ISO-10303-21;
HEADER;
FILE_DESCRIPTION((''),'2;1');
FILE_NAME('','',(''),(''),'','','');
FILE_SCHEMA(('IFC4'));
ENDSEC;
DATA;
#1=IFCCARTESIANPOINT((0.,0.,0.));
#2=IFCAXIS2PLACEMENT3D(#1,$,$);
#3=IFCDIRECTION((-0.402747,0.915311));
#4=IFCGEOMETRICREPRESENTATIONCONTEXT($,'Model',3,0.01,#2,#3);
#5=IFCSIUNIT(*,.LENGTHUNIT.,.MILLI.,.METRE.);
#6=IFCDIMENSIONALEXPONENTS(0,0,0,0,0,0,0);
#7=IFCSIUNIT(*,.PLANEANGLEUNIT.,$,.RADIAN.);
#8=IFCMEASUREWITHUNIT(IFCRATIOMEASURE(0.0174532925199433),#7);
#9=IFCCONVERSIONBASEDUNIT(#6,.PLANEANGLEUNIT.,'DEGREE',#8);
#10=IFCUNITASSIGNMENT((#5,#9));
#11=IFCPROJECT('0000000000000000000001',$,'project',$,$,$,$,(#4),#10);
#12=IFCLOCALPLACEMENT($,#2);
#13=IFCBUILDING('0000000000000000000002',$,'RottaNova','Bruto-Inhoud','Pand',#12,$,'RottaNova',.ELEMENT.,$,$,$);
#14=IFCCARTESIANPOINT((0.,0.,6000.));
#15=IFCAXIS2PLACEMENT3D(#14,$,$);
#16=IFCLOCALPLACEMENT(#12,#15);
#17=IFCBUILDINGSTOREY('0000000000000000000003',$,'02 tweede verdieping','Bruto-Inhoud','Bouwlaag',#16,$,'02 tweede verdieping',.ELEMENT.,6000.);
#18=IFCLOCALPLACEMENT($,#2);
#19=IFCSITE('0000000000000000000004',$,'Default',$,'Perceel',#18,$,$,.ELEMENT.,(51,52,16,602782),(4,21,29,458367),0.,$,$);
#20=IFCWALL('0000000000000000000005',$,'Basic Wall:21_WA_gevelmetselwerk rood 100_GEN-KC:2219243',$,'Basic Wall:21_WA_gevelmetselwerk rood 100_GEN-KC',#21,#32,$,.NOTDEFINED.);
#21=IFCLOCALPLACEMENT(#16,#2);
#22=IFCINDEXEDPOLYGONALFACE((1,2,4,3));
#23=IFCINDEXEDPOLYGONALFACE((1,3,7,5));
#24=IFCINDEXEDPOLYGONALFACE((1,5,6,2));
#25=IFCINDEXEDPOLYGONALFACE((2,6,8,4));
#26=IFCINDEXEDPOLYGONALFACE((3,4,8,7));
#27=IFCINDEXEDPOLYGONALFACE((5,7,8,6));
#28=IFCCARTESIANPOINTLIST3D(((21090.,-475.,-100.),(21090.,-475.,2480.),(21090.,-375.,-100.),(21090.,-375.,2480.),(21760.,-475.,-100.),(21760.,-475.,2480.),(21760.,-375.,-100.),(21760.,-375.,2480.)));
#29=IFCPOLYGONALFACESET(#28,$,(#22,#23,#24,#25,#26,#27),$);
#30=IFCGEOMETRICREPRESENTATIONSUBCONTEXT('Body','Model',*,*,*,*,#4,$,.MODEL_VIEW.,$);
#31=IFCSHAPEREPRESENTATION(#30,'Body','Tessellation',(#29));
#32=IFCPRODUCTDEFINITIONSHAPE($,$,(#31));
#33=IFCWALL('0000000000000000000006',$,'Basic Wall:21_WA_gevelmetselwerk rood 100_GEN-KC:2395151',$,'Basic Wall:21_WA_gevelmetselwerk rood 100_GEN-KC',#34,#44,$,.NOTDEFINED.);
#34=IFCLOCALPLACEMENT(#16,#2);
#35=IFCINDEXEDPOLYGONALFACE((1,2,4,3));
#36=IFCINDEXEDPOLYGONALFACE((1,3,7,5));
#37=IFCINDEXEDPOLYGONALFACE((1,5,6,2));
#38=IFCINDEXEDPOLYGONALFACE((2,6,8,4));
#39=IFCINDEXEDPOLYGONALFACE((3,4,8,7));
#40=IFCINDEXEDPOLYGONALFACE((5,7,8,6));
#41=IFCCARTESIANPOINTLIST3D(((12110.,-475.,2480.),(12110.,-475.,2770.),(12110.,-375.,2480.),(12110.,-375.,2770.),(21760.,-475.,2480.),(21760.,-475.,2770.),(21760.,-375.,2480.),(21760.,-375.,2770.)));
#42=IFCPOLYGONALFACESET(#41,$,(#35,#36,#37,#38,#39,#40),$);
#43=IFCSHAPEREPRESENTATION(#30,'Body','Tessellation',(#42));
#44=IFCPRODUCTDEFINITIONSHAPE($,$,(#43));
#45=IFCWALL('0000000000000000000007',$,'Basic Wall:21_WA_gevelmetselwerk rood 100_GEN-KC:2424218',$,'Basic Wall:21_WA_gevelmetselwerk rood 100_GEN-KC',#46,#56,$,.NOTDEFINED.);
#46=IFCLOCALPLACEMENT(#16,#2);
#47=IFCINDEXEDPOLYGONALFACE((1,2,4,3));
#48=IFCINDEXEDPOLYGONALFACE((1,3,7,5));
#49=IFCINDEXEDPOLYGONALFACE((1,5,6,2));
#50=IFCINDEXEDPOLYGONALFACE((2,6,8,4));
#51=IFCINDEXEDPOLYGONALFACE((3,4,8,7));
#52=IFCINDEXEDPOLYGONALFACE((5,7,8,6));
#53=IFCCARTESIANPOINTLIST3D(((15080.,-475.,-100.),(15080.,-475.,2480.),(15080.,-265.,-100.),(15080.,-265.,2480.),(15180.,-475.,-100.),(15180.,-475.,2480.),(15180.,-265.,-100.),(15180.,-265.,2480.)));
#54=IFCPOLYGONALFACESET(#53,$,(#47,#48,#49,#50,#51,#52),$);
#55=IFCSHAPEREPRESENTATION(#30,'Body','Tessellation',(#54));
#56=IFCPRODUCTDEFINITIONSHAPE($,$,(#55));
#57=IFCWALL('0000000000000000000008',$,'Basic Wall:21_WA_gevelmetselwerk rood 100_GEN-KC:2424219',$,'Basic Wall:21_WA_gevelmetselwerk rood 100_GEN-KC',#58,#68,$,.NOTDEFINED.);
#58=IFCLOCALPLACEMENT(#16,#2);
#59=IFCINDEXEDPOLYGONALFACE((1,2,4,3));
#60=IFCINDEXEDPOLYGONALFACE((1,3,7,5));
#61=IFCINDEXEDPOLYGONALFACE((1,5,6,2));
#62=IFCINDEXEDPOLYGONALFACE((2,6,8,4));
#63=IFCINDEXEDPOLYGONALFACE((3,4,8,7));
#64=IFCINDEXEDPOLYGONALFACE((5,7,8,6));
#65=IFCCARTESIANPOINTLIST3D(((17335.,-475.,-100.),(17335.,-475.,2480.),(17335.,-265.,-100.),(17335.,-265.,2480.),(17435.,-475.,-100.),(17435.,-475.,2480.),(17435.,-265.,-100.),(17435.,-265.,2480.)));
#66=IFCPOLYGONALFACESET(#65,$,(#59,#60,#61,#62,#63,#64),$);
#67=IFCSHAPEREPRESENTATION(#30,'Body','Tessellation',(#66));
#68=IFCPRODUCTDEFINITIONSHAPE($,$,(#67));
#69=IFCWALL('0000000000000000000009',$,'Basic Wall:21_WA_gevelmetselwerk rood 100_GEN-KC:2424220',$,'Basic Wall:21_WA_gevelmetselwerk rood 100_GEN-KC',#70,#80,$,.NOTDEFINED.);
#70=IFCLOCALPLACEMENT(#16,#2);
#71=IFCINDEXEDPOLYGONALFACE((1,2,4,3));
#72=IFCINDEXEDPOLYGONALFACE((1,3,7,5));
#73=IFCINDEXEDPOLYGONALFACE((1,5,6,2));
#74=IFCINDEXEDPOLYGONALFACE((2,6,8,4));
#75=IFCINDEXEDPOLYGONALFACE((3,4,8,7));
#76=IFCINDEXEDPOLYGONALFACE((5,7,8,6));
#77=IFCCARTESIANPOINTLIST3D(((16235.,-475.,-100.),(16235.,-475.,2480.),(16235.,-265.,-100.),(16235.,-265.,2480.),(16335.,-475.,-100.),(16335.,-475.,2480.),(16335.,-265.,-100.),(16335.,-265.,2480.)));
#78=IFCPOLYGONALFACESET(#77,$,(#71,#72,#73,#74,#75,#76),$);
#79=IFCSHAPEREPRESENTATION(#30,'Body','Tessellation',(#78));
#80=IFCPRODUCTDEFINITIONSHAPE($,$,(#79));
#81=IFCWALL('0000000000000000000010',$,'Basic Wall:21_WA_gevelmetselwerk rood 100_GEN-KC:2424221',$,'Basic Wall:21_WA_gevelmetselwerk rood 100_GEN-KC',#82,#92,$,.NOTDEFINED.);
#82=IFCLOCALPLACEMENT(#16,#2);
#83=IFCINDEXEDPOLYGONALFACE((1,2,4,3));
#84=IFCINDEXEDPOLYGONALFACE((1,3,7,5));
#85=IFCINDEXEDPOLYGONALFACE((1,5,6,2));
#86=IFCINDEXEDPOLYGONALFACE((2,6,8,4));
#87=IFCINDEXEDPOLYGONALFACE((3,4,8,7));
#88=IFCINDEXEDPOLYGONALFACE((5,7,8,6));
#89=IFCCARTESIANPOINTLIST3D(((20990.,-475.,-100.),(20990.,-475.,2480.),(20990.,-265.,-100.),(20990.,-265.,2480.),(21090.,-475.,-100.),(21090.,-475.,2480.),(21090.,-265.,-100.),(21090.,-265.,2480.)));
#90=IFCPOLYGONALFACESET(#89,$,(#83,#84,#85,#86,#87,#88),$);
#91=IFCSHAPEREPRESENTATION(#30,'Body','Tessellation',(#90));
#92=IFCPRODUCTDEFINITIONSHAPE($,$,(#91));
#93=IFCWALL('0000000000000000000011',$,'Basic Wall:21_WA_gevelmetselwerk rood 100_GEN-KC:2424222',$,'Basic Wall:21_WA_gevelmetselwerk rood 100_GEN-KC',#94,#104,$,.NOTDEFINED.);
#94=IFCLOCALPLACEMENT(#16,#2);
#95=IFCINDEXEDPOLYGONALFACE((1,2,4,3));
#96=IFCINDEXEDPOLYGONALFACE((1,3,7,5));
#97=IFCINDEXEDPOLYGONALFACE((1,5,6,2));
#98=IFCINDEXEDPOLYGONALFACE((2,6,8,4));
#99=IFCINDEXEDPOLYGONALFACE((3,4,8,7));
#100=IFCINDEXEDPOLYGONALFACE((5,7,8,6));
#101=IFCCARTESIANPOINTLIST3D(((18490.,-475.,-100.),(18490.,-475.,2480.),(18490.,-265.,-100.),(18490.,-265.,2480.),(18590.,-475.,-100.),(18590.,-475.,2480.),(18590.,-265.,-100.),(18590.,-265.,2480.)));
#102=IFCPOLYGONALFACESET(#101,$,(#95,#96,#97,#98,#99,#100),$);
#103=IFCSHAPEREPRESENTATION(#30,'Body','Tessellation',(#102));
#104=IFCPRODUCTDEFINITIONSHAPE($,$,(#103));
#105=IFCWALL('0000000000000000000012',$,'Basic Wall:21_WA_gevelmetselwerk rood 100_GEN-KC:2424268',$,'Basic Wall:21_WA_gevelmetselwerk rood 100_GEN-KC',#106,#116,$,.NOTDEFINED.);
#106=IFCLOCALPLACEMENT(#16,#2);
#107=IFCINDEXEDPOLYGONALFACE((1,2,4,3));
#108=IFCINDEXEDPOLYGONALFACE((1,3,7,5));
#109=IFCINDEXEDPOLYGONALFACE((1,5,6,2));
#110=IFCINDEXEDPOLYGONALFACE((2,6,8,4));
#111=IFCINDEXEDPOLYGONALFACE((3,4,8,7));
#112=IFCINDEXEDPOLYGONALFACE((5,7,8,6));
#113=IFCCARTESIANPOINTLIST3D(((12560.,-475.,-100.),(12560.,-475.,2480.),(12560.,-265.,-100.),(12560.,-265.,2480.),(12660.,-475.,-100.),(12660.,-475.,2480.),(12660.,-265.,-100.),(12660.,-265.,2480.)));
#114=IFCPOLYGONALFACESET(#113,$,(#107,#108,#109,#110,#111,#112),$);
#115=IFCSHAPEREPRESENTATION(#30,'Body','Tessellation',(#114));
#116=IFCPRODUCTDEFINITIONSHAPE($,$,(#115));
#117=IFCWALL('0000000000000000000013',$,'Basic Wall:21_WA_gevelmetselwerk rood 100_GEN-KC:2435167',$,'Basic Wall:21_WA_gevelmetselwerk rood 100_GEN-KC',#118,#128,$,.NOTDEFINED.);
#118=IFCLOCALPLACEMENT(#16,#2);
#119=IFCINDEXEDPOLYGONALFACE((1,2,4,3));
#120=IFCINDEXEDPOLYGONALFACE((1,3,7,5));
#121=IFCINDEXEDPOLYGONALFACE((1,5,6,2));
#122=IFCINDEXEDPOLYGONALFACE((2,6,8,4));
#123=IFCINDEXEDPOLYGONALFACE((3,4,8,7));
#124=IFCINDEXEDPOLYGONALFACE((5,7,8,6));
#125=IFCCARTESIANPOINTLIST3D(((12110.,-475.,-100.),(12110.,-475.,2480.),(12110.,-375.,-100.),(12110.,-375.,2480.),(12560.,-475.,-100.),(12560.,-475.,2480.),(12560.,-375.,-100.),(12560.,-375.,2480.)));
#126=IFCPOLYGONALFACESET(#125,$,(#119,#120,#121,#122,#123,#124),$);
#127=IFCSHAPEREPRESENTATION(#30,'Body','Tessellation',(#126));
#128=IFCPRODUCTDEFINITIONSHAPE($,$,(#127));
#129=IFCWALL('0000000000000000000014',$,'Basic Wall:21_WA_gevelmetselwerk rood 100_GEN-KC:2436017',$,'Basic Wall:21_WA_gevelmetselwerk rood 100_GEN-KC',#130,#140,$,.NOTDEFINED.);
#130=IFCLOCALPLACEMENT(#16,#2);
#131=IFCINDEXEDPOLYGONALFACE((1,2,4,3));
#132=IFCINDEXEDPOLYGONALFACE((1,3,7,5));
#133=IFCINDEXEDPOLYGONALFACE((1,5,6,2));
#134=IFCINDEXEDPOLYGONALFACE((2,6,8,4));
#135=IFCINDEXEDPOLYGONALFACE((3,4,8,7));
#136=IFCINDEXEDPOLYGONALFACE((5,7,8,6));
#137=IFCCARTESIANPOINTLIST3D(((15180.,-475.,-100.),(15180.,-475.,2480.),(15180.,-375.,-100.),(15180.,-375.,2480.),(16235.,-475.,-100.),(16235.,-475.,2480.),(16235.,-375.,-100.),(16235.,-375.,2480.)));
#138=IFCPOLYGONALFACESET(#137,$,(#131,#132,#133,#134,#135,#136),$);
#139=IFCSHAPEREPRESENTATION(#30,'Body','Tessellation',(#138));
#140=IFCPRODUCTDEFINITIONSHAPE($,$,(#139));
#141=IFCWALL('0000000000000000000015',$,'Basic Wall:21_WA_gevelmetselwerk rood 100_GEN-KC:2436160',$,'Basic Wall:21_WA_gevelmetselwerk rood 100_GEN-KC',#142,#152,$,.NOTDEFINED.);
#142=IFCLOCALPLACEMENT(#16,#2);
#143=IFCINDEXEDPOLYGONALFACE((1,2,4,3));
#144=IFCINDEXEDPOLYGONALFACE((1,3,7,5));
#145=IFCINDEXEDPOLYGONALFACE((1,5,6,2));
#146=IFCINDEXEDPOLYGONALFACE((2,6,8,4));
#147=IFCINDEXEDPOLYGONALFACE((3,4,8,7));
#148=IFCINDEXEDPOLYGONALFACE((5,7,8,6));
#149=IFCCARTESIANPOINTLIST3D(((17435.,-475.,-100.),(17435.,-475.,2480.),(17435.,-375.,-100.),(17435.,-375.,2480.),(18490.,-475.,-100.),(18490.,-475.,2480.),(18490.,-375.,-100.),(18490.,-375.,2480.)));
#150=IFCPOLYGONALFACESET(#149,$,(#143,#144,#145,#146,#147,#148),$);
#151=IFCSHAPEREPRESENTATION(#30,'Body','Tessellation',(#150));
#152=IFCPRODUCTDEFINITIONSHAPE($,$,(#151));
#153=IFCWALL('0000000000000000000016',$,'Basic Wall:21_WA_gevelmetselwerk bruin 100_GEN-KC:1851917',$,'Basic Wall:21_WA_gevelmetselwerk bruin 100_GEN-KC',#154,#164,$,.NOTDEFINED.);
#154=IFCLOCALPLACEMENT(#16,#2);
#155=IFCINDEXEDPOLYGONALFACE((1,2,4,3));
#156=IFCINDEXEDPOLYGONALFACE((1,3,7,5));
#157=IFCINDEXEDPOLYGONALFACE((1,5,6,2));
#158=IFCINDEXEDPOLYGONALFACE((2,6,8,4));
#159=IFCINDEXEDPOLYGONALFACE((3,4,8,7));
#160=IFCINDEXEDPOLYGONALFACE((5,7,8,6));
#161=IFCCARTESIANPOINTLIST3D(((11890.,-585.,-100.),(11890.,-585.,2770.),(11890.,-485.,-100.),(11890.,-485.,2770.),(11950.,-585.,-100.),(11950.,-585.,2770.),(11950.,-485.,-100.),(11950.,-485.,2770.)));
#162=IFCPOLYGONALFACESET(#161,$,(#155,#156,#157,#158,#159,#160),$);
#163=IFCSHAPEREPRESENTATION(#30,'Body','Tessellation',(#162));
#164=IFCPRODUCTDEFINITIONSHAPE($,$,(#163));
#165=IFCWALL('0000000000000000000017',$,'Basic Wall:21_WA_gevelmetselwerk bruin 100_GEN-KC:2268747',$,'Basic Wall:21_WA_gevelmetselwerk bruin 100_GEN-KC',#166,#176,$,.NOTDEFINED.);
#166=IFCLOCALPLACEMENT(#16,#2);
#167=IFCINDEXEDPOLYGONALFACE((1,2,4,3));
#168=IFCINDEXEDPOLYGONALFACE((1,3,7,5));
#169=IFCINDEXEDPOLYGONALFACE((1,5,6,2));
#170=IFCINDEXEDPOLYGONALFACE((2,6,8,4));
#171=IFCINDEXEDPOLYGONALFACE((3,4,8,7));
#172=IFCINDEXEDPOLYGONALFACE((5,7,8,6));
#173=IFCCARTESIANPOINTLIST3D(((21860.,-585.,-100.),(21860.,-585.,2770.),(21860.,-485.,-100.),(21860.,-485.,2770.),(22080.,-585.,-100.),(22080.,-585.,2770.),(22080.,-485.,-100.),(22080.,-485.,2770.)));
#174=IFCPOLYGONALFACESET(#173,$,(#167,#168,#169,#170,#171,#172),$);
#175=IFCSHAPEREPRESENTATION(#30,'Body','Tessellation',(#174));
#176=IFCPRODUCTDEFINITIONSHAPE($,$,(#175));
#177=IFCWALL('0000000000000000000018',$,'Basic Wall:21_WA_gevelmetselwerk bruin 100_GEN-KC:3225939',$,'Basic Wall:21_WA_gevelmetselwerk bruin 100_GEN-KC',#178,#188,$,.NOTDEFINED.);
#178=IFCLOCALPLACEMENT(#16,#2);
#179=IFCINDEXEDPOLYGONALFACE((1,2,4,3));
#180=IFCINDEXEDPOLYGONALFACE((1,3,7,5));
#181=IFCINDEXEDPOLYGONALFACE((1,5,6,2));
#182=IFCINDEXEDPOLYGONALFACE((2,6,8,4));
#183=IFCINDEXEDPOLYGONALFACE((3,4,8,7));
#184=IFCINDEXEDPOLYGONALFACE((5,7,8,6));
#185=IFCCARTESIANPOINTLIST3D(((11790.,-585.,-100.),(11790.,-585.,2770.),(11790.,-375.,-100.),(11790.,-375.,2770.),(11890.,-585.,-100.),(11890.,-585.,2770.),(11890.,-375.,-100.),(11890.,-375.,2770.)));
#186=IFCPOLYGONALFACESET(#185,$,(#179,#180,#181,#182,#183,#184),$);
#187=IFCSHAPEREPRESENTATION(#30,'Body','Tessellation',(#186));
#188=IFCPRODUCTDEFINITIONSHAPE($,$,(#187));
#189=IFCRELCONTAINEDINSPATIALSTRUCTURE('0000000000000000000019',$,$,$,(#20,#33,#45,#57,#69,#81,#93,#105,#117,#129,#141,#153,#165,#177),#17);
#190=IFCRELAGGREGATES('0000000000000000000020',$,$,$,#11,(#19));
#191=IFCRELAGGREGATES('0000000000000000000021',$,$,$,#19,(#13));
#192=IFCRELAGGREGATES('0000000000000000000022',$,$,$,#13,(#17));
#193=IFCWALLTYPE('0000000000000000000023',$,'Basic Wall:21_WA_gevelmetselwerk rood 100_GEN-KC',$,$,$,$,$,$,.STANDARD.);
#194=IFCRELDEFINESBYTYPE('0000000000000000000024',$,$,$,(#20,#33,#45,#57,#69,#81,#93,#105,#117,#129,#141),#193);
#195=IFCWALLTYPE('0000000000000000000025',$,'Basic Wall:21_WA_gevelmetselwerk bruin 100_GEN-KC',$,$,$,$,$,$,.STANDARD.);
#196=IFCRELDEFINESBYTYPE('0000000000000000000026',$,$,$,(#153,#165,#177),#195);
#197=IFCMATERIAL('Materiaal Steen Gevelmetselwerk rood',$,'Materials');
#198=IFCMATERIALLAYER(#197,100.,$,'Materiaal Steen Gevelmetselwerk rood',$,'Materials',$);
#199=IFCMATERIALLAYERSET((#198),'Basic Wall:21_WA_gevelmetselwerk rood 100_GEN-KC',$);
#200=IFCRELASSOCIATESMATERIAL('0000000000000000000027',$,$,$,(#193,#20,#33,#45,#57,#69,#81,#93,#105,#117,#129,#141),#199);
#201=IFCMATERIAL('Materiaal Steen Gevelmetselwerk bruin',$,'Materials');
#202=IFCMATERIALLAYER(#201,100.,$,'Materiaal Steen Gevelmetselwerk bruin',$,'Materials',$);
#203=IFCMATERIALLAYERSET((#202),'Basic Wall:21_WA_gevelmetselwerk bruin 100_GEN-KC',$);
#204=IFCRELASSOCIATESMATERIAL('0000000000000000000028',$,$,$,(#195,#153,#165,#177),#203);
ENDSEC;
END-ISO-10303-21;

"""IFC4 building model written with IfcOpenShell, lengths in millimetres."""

from ifc_helpers import new_model, entity, si_unit, converted_unit, direction, frame, frame_2d, origin, place, context, subcontext, project, spatial, rectangle, extrude, material, layer, layer_set, type_object, element, save


model = new_model("IFC4")

# Units and contexts
model_context = context("Model", 3, precision=0.01, world=origin(), true_north=direction((-0.402747, 0.915311)))
body_context = subcontext(model_context, "Body", "Model", "MODEL_VIEW")
ifc_project = project(units=[si_unit("LENGTHUNIT", "METRE", prefix="MILLI"), converted_unit("PLANEANGLEUNIT", "DEGREE", entity("IfcRatioMeasure", 0.0174532925199433), si_unit("PLANEANGLEUNIT", "RADIAN"), dimensions=[0, 0, 0, 0, 0, 0, 0])], contexts=[model_context])

# Site, building, storey
site_placement = place(None, origin())
site = spatial("IfcSite", under=ifc_project, at=site_placement, Name="Default", ObjectType="Perceel", CompositionType="ELEMENT", RefLatitude=(51, 52, 16, 602782), RefLongitude=(4, 21, 29, 458367), RefElevation=0.0)
building_placement = place(None, origin())
building = spatial("IfcBuilding", under=site, at=building_placement, Name="RottaNova", Description="Bruto-Inhoud", ObjectType="Pand", LongName="RottaNova", CompositionType="ELEMENT")
storey_placement = place(building_placement, frame((0.0, 0.0, 6000.0)))
storey = spatial("IfcBuildingStorey", under=building, at=storey_placement, Name="02 tweede verdieping", Description="Bruto-Inhoud", ObjectType="Bouwlaag", LongName="02 tweede verdieping", CompositionType="ELEMENT", Elevation=6000.0)

# Walls
ifc_material_1 = material(Name="Materiaal Steen Gevelmetselwerk rood", Category="Materials")
ifc_layer_1 = layer(ifc_material_1, 100.0, Name="Materiaal Steen Gevelmetselwerk rood", Category="Materials")
ifc_layer_set_1 = layer_set([ifc_layer_1], Name="Basic Wall:21_WA_gevelmetselwerk rood 100_GEN-KC")
wall_type_1 = type_object("IfcWallType", Name="Basic Wall:21_WA_gevelmetselwerk rood 100_GEN-KC", PredefinedType="STANDARD", material=ifc_layer_set_1)
wall_1_placement = place(storey_placement, frame((21760.0, -425.0, -100.0), z_axis=(0.0, 0.0, 1.0), x_axis=(-1.0, 0.0, 0.0)))
element("IfcWall", 1, at=wall_1_placement, inside=storey, type_object=wall_type_1, material=ifc_layer_set_1, Name="Basic Wall:21_WA_gevelmetselwerk rood 100_GEN-KC:2219243", ObjectType="Basic Wall:21_WA_gevelmetselwerk rood 100_GEN-KC", PredefinedType="NOTDEFINED", context=body_context, shape_type="SweptSolid", body=[
    extrude(rectangle(XDim=670.0, YDim=100.0, at=frame_2d((335.0, 0.0), x_axis=(-1.0, 0.0))), origin(), (0.0, 0.0, 1.0), 2580.0),
])
wall_2_placement = place(storey_placement, frame((21760.0, -425.0, 2480.0), z_axis=(0.0, 0.0, 1.0), x_axis=(-1.0, 0.0, 0.0)))
element("IfcWall", 2, at=wall_2_placement, inside=storey, type_object=wall_type_1, material=ifc_layer_set_1, Name="Basic Wall:21_WA_gevelmetselwerk rood 100_GEN-KC:2395151", ObjectType="Basic Wall:21_WA_gevelmetselwerk rood 100_GEN-KC", PredefinedType="NOTDEFINED", context=body_context, shape_type="SweptSolid", body=[
    extrude(rectangle(XDim=9650.0, YDim=100.0, at=frame_2d((4825.0, 0.0), x_axis=(-1.0, 0.0))), origin(), (0.0, 0.0, 1.0), 290.0),
])
for number, where, z_axis, x_axis, name in (
    (3, (15130.0, -265.0, -100.0), (0.0, 0.0, 1.0), (0.0, -1.0, 0.0), "Basic Wall:21_WA_gevelmetselwerk rood 100_GEN-KC:2424218"),
    (4, (17385.0, -265.0, -100.0), (0.0, 0.0, 1.0), (0.0, -1.0, 0.0), "Basic Wall:21_WA_gevelmetselwerk rood 100_GEN-KC:2424219"),
    (5, (16285.0, -265.0, -100.0), (0.0, 0.0, 1.0), (0.0, -1.0, 0.0), "Basic Wall:21_WA_gevelmetselwerk rood 100_GEN-KC:2424220"),
):
    element("IfcWall", number, at=place(storey_placement, frame(where, z_axis=z_axis, x_axis=x_axis)), inside=storey, type_object=wall_type_1, material=ifc_layer_set_1, Name=name, ObjectType="Basic Wall:21_WA_gevelmetselwerk rood 100_GEN-KC", PredefinedType="NOTDEFINED", context=body_context, shape_type="SweptSolid", body=[
        extrude(rectangle(XDim=210.0, YDim=100.0, at=frame_2d((105.0, 0.0), x_axis=(-1.0, 0.0))), origin(), (0.0, 0.0, 1.0), 2580.0),
    ])
wall_3_placement = place(storey_placement, frame((21040.0, -265.0, -100.0), z_axis=(0.0, 0.0, 1.0), x_axis=(0.0, -1.0, 0.0)))
element("IfcWall", 6, at=wall_3_placement, inside=storey, type_object=wall_type_1, material=ifc_layer_set_1, Name="Basic Wall:21_WA_gevelmetselwerk rood 100_GEN-KC:2424221", ObjectType="Basic Wall:21_WA_gevelmetselwerk rood 100_GEN-KC", PredefinedType="NOTDEFINED", context=body_context, shape_type="SweptSolid", body=[
    extrude(rectangle(XDim=210.0, YDim=100.0, at=frame_2d((105.0, 0.0), x_axis=(-1.0, 0.0))), origin(), (0.0, 0.0, 1.0), 2580.0),
])
wall_4_placement = place(storey_placement, frame((18540.0, -265.0, -100.0), z_axis=(0.0, 0.0, 1.0), x_axis=(0.0, -1.0, 0.0)))
element("IfcWall", 7, at=wall_4_placement, inside=storey, type_object=wall_type_1, material=ifc_layer_set_1, Name="Basic Wall:21_WA_gevelmetselwerk rood 100_GEN-KC:2424222", ObjectType="Basic Wall:21_WA_gevelmetselwerk rood 100_GEN-KC", PredefinedType="NOTDEFINED", context=body_context, shape_type="SweptSolid", body=[
    extrude(rectangle(XDim=210.0, YDim=100.0, at=frame_2d((105.0, 0.0), x_axis=(-1.0, 0.0))), origin(), (0.0, 0.0, 1.0), 2580.0),
])
wall_5_placement = place(storey_placement, frame((12610.0, -265.0, -100.0), z_axis=(0.0, 0.0, 1.0), x_axis=(0.0, -1.0, 0.0)))
element("IfcWall", 8, at=wall_5_placement, inside=storey, type_object=wall_type_1, material=ifc_layer_set_1, Name="Basic Wall:21_WA_gevelmetselwerk rood 100_GEN-KC:2424268", ObjectType="Basic Wall:21_WA_gevelmetselwerk rood 100_GEN-KC", PredefinedType="NOTDEFINED", context=body_context, shape_type="SweptSolid", body=[
    extrude(rectangle(XDim=210.0, YDim=100.0, at=frame_2d((105.0, 0.0), x_axis=(-1.0, 0.0))), origin(), (0.0, 0.0, 1.0), 2580.0),
])
wall_6_placement = place(storey_placement, frame((12560.0, -425.0, -100.0), z_axis=(0.0, 0.0, 1.0), x_axis=(-1.0, 0.0, 0.0)))
element("IfcWall", 9, at=wall_6_placement, inside=storey, type_object=wall_type_1, material=ifc_layer_set_1, Name="Basic Wall:21_WA_gevelmetselwerk rood 100_GEN-KC:2435167", ObjectType="Basic Wall:21_WA_gevelmetselwerk rood 100_GEN-KC", PredefinedType="NOTDEFINED", context=body_context, shape_type="SweptSolid", body=[
    extrude(rectangle(XDim=450.0, YDim=100.0, at=frame_2d((225.0, 0.0), x_axis=(-1.0, 0.0))), origin(), (0.0, 0.0, 1.0), 2580.0),
])
wall_7_placement = place(storey_placement, frame((16235.0, -425.0, -100.0), z_axis=(0.0, 0.0, 1.0), x_axis=(-1.0, 0.0, 0.0)))
element("IfcWall", 10, at=wall_7_placement, inside=storey, type_object=wall_type_1, material=ifc_layer_set_1, Name="Basic Wall:21_WA_gevelmetselwerk rood 100_GEN-KC:2436017", ObjectType="Basic Wall:21_WA_gevelmetselwerk rood 100_GEN-KC", PredefinedType="NOTDEFINED", context=body_context, shape_type="SweptSolid", body=[
    extrude(rectangle(XDim=1055.0, YDim=100.0, at=frame_2d((527.5, 0.0), x_axis=(-1.0, 0.0))), origin(), (0.0, 0.0, 1.0), 2580.0),
])
wall_8_placement = place(storey_placement, frame((18490.0, -425.0, -100.0), z_axis=(0.0, 0.0, 1.0), x_axis=(-1.0, 0.0, 0.0)))
element("IfcWall", 11, at=wall_8_placement, inside=storey, type_object=wall_type_1, material=ifc_layer_set_1, Name="Basic Wall:21_WA_gevelmetselwerk rood 100_GEN-KC:2436160", ObjectType="Basic Wall:21_WA_gevelmetselwerk rood 100_GEN-KC", PredefinedType="NOTDEFINED", context=body_context, shape_type="SweptSolid", body=[
    extrude(rectangle(XDim=1055.0, YDim=100.0, at=frame_2d((527.5, 0.0), x_axis=(-1.0, 0.0))), origin(), (0.0, 0.0, 1.0), 2580.0),
])
ifc_material_2 = material(Name="Materiaal Steen Gevelmetselwerk bruin", Category="Materials")
ifc_layer_2 = layer(ifc_material_2, 100.0, Name="Materiaal Steen Gevelmetselwerk bruin", Category="Materials")
ifc_layer_set_2 = layer_set([ifc_layer_2], Name="Basic Wall:21_WA_gevelmetselwerk bruin 100_GEN-KC")
wall_type_2 = type_object("IfcWallType", Name="Basic Wall:21_WA_gevelmetselwerk bruin 100_GEN-KC", PredefinedType="STANDARD", material=ifc_layer_set_2)
wall_9_placement = place(storey_placement, frame((11890.0, -535.0, -100.0)))
element("IfcWall", 12, at=wall_9_placement, inside=storey, type_object=wall_type_2, material=ifc_layer_set_2, Name="Basic Wall:21_WA_gevelmetselwerk bruin 100_GEN-KC:1851917", ObjectType="Basic Wall:21_WA_gevelmetselwerk bruin 100_GEN-KC", PredefinedType="NOTDEFINED", context=body_context, shape_type="SweptSolid", body=[
    extrude(rectangle(XDim=60.0, YDim=100.0, at=frame_2d((30.0, 0.0), x_axis=(-1.0, 0.0))), origin(), (0.0, 0.0, 1.0), 2870.0),
])
wall_10_placement = place(storey_placement, frame((21860.0, -535.0, -100.0)))
element("IfcWall", 13, at=wall_10_placement, inside=storey, type_object=wall_type_2, material=ifc_layer_set_2, Name="Basic Wall:21_WA_gevelmetselwerk bruin 100_GEN-KC:2268747", ObjectType="Basic Wall:21_WA_gevelmetselwerk bruin 100_GEN-KC", PredefinedType="NOTDEFINED", context=body_context, shape_type="SweptSolid", body=[
    extrude(rectangle(XDim=220.0, YDim=100.0, at=frame_2d((110.0, 0.0), x_axis=(-1.0, 0.0))), origin(), (0.0, 0.0, 1.0), 2870.0),
])
wall_11_placement = place(storey_placement, frame((11840.0, -585.0, -100.0), z_axis=(0.0, 0.0, 1.0), x_axis=(0.0, 1.0, 0.0)))
element("IfcWall", 14, at=wall_11_placement, inside=storey, type_object=wall_type_2, material=ifc_layer_set_2, Name="Basic Wall:21_WA_gevelmetselwerk bruin 100_GEN-KC:3225939", ObjectType="Basic Wall:21_WA_gevelmetselwerk bruin 100_GEN-KC", PredefinedType="NOTDEFINED", context=body_context, shape_type="SweptSolid", body=[
    extrude(rectangle(XDim=210.0, YDim=100.0, at=frame_2d((105.0, 0.0), x_axis=(-1.0, 0.0))), origin(), (0.0, 0.0, 1.0), 2870.0),
])

save(model, "model.ifc")
